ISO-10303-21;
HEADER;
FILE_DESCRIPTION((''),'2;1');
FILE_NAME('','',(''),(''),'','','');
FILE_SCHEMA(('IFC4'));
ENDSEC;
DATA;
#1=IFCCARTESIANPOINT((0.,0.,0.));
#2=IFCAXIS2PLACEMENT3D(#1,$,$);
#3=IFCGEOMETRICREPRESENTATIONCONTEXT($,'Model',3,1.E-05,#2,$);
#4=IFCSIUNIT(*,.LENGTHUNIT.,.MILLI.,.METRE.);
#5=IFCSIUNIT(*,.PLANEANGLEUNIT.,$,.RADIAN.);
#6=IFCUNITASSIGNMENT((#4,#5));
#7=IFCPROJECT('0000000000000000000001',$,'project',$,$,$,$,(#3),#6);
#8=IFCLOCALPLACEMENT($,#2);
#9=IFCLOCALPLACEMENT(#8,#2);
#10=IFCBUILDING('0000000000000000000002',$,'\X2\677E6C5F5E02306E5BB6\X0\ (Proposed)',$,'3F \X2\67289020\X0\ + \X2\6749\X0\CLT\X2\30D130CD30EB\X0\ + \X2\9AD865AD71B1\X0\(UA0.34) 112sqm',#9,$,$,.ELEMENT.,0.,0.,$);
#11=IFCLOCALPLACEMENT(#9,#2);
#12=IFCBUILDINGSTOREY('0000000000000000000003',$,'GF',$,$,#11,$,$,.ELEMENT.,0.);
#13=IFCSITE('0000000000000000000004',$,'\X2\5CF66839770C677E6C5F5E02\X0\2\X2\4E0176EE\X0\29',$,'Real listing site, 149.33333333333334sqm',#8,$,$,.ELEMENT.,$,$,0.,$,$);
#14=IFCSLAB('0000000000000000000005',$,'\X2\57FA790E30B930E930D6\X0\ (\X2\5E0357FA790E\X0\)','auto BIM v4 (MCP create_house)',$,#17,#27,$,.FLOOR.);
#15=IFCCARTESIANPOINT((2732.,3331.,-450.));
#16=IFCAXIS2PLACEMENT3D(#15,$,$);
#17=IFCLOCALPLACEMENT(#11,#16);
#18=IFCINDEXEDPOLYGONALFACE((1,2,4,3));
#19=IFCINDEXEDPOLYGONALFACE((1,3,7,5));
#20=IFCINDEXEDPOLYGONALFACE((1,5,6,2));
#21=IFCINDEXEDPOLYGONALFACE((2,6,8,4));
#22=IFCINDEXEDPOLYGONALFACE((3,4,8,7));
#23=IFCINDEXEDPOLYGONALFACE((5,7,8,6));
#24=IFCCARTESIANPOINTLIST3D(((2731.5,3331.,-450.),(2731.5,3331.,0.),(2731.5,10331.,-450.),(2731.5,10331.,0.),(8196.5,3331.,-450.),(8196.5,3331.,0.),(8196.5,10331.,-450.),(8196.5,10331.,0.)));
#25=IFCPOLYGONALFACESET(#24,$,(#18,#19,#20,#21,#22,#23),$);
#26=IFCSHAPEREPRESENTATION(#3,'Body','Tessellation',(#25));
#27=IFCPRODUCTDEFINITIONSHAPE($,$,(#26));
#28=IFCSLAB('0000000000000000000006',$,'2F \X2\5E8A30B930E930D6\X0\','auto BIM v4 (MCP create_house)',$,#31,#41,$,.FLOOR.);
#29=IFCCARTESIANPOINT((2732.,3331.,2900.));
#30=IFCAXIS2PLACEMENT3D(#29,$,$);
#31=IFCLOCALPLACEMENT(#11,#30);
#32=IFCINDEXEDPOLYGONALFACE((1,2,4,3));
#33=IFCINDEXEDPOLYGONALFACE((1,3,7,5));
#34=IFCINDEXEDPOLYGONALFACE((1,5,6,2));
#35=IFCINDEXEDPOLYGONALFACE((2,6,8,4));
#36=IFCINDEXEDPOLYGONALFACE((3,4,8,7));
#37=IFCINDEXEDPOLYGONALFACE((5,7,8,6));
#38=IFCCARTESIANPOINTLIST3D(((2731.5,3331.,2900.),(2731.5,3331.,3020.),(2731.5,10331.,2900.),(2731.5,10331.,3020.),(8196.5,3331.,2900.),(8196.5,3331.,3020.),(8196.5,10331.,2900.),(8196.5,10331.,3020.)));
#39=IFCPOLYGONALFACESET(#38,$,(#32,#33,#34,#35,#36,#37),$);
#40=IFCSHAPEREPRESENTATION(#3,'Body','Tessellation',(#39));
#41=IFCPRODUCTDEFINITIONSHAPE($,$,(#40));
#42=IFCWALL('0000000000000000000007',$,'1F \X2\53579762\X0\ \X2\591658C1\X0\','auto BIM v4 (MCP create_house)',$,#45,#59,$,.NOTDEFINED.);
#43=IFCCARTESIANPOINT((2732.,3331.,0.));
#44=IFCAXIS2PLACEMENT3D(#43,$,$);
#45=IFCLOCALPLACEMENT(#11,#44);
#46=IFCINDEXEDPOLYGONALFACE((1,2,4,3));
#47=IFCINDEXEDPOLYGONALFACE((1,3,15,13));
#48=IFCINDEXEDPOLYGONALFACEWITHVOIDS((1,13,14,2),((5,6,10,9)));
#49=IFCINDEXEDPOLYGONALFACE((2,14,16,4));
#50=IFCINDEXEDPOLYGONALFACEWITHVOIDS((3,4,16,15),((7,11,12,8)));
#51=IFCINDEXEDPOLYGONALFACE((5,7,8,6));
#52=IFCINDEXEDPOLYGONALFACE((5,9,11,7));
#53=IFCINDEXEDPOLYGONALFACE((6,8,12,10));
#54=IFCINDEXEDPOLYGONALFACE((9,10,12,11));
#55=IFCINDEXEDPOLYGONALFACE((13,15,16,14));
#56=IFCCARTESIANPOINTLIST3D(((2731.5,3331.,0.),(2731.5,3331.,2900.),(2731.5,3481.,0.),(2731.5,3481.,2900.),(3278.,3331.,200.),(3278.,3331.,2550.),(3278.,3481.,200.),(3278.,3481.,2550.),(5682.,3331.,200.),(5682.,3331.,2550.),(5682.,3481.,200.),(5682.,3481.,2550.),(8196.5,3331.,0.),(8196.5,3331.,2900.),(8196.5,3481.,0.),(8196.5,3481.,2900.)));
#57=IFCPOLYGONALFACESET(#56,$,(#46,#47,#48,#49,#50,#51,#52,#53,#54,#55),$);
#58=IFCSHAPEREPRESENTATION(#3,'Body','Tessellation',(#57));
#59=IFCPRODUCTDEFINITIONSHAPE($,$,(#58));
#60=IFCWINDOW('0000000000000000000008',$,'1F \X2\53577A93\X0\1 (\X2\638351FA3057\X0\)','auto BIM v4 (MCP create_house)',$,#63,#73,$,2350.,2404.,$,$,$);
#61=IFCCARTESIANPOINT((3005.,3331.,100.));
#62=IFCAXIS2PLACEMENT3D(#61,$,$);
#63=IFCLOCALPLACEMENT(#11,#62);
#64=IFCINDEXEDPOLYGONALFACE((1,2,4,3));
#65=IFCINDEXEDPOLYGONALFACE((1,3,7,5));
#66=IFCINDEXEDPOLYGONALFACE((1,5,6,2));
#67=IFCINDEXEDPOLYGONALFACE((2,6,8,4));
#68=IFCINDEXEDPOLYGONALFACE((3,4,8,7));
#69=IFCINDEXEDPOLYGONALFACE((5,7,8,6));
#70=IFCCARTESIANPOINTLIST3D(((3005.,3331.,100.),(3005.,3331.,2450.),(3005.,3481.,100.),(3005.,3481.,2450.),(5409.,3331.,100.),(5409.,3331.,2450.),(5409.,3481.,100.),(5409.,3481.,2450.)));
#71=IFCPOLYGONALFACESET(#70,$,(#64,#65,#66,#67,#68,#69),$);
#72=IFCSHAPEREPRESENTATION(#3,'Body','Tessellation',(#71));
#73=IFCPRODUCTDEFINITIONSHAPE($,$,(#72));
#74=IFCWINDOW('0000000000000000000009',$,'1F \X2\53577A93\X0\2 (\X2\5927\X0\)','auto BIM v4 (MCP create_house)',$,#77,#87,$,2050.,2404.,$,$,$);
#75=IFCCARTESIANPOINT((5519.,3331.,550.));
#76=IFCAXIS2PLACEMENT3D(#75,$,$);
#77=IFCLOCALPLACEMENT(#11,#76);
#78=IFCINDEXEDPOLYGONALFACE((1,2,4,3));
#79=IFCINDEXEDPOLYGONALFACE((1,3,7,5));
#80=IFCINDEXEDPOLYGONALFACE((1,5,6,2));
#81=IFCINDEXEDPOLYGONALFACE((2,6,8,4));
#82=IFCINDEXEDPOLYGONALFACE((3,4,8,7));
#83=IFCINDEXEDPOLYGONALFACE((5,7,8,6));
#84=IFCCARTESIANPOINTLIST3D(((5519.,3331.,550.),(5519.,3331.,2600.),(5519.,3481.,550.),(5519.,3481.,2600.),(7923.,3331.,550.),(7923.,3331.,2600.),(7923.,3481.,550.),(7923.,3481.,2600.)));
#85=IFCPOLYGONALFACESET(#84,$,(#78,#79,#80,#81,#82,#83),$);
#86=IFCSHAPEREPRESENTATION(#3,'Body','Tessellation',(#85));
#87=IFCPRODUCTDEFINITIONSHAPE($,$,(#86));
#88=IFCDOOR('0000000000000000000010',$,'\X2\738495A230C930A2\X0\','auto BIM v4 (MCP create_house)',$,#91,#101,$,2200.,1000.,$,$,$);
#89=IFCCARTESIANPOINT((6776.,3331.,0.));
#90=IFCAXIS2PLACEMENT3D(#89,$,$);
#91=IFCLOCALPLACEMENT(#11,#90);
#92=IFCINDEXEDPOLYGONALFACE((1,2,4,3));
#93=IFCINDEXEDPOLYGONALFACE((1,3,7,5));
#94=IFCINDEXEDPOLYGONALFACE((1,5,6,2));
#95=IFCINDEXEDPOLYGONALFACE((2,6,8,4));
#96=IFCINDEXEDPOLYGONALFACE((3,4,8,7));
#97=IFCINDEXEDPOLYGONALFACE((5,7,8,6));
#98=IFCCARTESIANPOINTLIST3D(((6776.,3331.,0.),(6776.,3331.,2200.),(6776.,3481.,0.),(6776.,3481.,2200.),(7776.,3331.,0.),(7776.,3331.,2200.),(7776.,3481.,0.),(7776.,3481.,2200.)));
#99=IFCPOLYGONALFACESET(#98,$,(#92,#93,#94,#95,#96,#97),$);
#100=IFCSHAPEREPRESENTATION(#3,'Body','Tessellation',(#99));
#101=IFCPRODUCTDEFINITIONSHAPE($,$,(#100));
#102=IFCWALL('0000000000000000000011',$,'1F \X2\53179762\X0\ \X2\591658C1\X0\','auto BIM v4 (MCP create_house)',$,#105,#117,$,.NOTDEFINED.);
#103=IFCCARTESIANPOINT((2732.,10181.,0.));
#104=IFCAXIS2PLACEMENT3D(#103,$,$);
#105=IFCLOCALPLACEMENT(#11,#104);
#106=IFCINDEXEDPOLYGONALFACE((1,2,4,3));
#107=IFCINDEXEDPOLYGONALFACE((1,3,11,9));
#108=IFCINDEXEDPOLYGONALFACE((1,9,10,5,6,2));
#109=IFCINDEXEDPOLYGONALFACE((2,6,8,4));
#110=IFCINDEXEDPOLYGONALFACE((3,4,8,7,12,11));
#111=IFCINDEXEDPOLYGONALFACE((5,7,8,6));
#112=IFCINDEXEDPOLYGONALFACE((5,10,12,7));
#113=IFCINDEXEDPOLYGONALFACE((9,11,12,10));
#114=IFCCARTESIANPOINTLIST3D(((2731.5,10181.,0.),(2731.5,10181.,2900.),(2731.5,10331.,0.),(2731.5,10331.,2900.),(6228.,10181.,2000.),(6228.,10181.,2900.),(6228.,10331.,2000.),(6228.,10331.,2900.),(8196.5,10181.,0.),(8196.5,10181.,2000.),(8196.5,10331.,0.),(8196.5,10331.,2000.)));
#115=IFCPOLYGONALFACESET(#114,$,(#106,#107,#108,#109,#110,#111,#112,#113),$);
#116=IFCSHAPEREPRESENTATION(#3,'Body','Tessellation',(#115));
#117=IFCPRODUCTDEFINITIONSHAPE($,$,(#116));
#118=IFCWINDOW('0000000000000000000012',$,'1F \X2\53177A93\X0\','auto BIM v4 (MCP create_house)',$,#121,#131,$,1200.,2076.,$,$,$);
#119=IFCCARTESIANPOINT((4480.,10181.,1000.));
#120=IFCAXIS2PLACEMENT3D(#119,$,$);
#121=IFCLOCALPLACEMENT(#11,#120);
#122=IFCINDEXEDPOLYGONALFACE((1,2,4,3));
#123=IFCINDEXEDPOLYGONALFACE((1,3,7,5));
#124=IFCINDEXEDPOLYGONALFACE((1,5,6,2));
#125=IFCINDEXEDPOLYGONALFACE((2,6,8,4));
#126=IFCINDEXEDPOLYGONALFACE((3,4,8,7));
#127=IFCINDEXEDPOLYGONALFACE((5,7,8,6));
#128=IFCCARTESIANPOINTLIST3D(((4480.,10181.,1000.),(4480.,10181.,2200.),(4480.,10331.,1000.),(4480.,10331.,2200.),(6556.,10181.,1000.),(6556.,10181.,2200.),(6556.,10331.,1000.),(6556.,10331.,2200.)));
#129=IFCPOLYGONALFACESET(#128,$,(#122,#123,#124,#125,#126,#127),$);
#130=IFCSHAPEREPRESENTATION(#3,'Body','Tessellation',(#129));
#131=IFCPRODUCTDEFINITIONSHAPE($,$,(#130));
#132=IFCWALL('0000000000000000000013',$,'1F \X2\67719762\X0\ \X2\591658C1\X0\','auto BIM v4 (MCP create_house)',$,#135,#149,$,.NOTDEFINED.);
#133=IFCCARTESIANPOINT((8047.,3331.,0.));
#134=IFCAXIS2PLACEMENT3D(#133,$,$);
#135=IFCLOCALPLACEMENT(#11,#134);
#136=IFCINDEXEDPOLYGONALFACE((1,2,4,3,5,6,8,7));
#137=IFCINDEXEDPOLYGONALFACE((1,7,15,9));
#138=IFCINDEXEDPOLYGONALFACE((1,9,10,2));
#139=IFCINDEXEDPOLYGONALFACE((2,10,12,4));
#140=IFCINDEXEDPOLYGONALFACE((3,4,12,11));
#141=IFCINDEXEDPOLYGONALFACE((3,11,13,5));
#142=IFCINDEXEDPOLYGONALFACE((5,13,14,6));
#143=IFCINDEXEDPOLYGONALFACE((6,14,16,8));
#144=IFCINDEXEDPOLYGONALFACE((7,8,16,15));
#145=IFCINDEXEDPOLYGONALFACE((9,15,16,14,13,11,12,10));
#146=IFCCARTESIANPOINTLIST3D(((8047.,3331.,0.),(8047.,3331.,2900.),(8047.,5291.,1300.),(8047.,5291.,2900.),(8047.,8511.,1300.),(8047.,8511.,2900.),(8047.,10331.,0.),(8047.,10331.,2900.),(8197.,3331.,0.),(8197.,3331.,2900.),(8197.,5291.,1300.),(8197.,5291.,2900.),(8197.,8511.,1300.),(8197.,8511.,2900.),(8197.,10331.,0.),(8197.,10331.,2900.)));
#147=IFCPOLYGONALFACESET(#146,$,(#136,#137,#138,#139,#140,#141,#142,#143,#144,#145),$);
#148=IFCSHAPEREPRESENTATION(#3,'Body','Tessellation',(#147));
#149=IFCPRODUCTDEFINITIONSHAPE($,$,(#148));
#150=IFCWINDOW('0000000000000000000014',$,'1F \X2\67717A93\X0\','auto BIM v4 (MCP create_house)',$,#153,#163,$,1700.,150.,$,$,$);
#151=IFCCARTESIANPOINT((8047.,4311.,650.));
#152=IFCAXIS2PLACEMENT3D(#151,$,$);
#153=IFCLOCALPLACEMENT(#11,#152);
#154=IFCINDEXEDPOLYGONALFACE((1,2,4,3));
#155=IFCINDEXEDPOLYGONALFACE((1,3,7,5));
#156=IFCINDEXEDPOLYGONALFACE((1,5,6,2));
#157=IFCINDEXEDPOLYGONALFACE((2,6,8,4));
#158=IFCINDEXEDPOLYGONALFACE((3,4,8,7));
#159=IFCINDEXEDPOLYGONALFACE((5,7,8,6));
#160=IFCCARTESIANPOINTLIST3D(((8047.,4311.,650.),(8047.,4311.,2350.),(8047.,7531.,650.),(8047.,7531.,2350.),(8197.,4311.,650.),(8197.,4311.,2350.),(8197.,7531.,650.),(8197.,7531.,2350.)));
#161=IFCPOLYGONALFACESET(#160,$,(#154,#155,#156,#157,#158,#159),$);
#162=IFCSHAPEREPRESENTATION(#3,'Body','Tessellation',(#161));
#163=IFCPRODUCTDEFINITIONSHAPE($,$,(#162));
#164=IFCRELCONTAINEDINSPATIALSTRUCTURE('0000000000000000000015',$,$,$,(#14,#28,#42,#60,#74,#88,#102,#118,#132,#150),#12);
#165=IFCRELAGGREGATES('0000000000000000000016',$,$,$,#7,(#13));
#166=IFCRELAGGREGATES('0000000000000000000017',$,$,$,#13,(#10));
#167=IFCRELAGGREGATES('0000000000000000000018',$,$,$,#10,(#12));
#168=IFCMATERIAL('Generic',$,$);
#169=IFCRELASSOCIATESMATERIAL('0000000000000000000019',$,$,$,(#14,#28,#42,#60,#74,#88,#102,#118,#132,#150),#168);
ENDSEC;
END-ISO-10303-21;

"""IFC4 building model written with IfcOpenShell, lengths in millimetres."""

from ifc_helpers import new_model, si_unit, frame, frame_2d, origin, place, context, project, spatial, rectangle, extrude, material, element, fill, save


model = new_model("IFC4")

# Units and contexts
model_context = context("Model", 3, precision=1e-05, world=origin())
ifc_project = project(units=[si_unit("LENGTHUNIT", "METRE", prefix="MILLI"), si_unit("PLANEANGLEUNIT", "RADIAN")], contexts=[model_context])

# Site, building, storey
site_placement = place(None, origin())
site = spatial("IfcSite", under=ifc_project, at=site_placement, Name="島根県松江市2丁目29", ObjectType="Real listing site, 149.33333333333334sqm", CompositionType="ELEMENT", RefElevation=0.0)
building_placement = place(site_placement, origin())
building = spatial("IfcBuilding", under=site, at=building_placement, Name="松江市の家 (Proposed)", ObjectType="3F 木造 + 杉CLTパネル + 高断熱(UA0.34) 112sqm", CompositionType="ELEMENT", ElevationOfRefHeight=0.0, ElevationOfTerrain=0.0)
storey_placement = place(building_placement, origin())
storey = spatial("IfcBuildingStorey", under=building, at=storey_placement, Name="GF", CompositionType="ELEMENT", Elevation=0.0)

# Slabs
ifc_material = material(Name="Generic")
slab_1_placement = place(storey_placement, frame((2732.0, 3331.0, -450.0)))
element("IfcSlab", 1, at=slab_1_placement, inside=storey, material=ifc_material, Name="基礎スラブ (布基礎)", Description="auto BIM v4 (MCP create_house)", PredefinedType="FLOOR", context=model_context, shape_type="SweptSolid", body=[
    extrude(rectangle(XDim=5465.0, YDim=7000.0, at=frame_2d((2732.0, 3500.0))), frame((2732.0, 3331.0, -450.0)), (0.0, 0.0, 1.0), 450.0),
])
slab_2_placement = place(storey_placement, frame((2732.0, 3331.0, 2900.0)))
element("IfcSlab", 2, at=slab_2_placement, inside=storey, material=ifc_material, Name="2F 床スラブ", Description="auto BIM v4 (MCP create_house)", PredefinedType="FLOOR", context=model_context, shape_type="SweptSolid", body=[
    extrude(rectangle(XDim=5465.0, YDim=7000.0, at=frame_2d((2732.0, 3500.0))), frame((2732.0, 3331.0, 2900.0)), (0.0, 0.0, 1.0), 120.0),
])

# Wall, openings, windows, door
wall_1_placement = place(storey_placement, frame((2732.0, 3331.0, 0.0)))
wall_1 = element("IfcWall", 3, at=wall_1_placement, inside=storey, material=ifc_material, Name="1F 南面 外壁", Description="auto BIM v4 (MCP create_house)", PredefinedType="NOTDEFINED", context=model_context, shape_type="SweptSolid", body=[
    extrude(rectangle(XDim=5465.0, YDim=150.0, at=frame_2d((2732.0, 75.0))), frame((2732.0, 3331.0, 0.0)), (0.0, 0.0, 1.0), 2900.0),
])
opening_1_placement = place(storey_placement, frame((3005.0, 3331.0, 100.0)))
opening_1 = element("IfcOpeningElement", 4, at=opening_1_placement, cuts=wall_1, PredefinedType="NOTDEFINED", context=model_context, shape_type="SweptSolid", body=[
    extrude(rectangle(XDim=2404.0, YDim=150.0, at=frame_2d((1202.0, 75.0))), frame((3005.0, 3331.0, 100.0)), (0.0, 0.0, 1.0), 2350.0),
])
opening_2_placement = place(storey_placement, frame((5519.0, 3331.0, 550.0)))
opening_2 = element("IfcOpeningElement", 5, at=opening_2_placement, cuts=wall_1, PredefinedType="NOTDEFINED", context=model_context, shape_type="SweptSolid", body=[
    extrude(rectangle(XDim=2404.0, YDim=150.0, at=frame_2d((1202.0, 75.0))), frame((5519.0, 3331.0, 550.0)), (0.0, 0.0, 1.0), 2050.0),
])
opening_3_placement = place(storey_placement, frame((6776.0, 3331.0, 0.0)))
opening_3 = element("IfcOpeningElement", 6, at=opening_3_placement, cuts=wall_1, PredefinedType="NOTDEFINED", context=model_context, shape_type="SweptSolid", body=[
    extrude(rectangle(XDim=1000.0, YDim=150.0, at=frame_2d((500.0, 75.0))), frame((6776.0, 3331.0, 0.0)), (0.0, 0.0, 1.0), 2200.0),
])
window_1_placement = place(storey_placement, frame((3005.0, 3331.0, 100.0)))
window_1 = element("IfcWindow", 7, at=window_1_placement, inside=storey, material=ifc_material, Name="1F 南窓1 (掃出し)", Description="auto BIM v4 (MCP create_house)", OverallHeight=2350.0, OverallWidth=2404.0, context=model_context, shape_type="SweptSolid", body=[
    extrude(rectangle(XDim=2404.0, YDim=150.0, at=frame_2d((1202.0, 75.0))), frame((3005.0, 3331.0, 100.0)), (0.0, 0.0, 1.0), 2350.0),
])
fill(opening_1, window_1)
window_2_placement = place(storey_placement, frame((5519.0, 3331.0, 550.0)))
window_2 = element("IfcWindow", 8, at=window_2_placement, inside=storey, material=ifc_material, Name="1F 南窓2 (大)", Description="auto BIM v4 (MCP create_house)", OverallHeight=2050.0, OverallWidth=2404.0, context=model_context, shape_type="SweptSolid", body=[
    extrude(rectangle(XDim=2404.0, YDim=150.0, at=frame_2d((1202.0, 75.0))), frame((5519.0, 3331.0, 550.0)), (0.0, 0.0, 1.0), 2050.0),
])
fill(opening_2, window_2)
door_placement = place(storey_placement, frame((6776.0, 3331.0, 0.0)))
door = element("IfcDoor", 9, at=door_placement, inside=storey, material=ifc_material, Name="玄関ドア", Description="auto BIM v4 (MCP create_house)", OverallHeight=2200.0, OverallWidth=1000.0, context=model_context, shape_type="SweptSolid", body=[
    extrude(rectangle(XDim=1000.0, YDim=150.0, at=frame_2d((500.0, 75.0))), frame((6776.0, 3331.0, 0.0)), (0.0, 0.0, 1.0), 2200.0),
])
fill(opening_3, door)

# Walls, openings, windows
wall_2_placement = place(storey_placement, frame((2732.0, 10181.0, 0.0)))
wall_2 = element("IfcWall", 10, at=wall_2_placement, inside=storey, material=ifc_material, Name="1F 北面 外壁", Description="auto BIM v4 (MCP create_house)", PredefinedType="NOTDEFINED", context=model_context, shape_type="SweptSolid", body=[
    extrude(rectangle(XDim=5465.0, YDim=150.0, at=frame_2d((2732.0, 75.0))), frame((2732.0, 10181.0, 0.0)), (0.0, 0.0, 1.0), 2900.0),
])
opening_4_placement = place(storey_placement, frame((4480.0, 10181.0, 1000.0)))
opening_4 = element("IfcOpeningElement", 11, at=opening_4_placement, cuts=wall_2, PredefinedType="NOTDEFINED", context=model_context, shape_type="SweptSolid", body=[
    extrude(rectangle(XDim=2076.0, YDim=150.0, at=frame_2d((1038.0, 75.0))), frame((4480.0, 10181.0, 1000.0)), (0.0, 0.0, 1.0), 1200.0),
])
window_3_placement = place(storey_placement, frame((4480.0, 10181.0, 1000.0)))
window_3 = element("IfcWindow", 12, at=window_3_placement, inside=storey, material=ifc_material, Name="1F 北窓", Description="auto BIM v4 (MCP create_house)", OverallHeight=1200.0, OverallWidth=2076.0, context=model_context, shape_type="SweptSolid", body=[
    extrude(rectangle(XDim=2076.0, YDim=150.0, at=frame_2d((1038.0, 75.0))), frame((4480.0, 10181.0, 1000.0)), (0.0, 0.0, 1.0), 1200.0),
])
fill(opening_4, window_3)
wall_3_placement = place(storey_placement, frame((8047.0, 3331.0, 0.0)))
wall_3 = element("IfcWall", 13, at=wall_3_placement, inside=storey, material=ifc_material, Name="1F 東面 外壁", Description="auto BIM v4 (MCP create_house)", PredefinedType="NOTDEFINED", context=model_context, shape_type="SweptSolid", body=[
    extrude(rectangle(XDim=150.0, YDim=7000.0, at=frame_2d((75.0, 3500.0))), frame((8047.0, 3331.0, 0.0)), (0.0, 0.0, 1.0), 2900.0),
])
opening_5_placement = place(storey_placement, frame((8047.0, 4311.0, 650.0)))
opening_5 = element("IfcOpeningElement", 14, at=opening_5_placement, cuts=wall_3, PredefinedType="NOTDEFINED", context=model_context, shape_type="SweptSolid", body=[
    extrude(rectangle(XDim=150.0, YDim=3220.0, at=frame_2d((75.0, 1610.0))), frame((8047.0, 4311.0, 650.0)), (0.0, 0.0, 1.0), 1700.0),
])
window_4_placement = place(storey_placement, frame((8047.0, 4311.0, 650.0)))
window_4 = element("IfcWindow", 15, at=window_4_placement, inside=storey, material=ifc_material, Name="1F 東窓", Description="auto BIM v4 (MCP create_house)", OverallHeight=1700.0, OverallWidth=150.0, context=model_context, shape_type="SweptSolid", body=[
    extrude(rectangle(XDim=150.0, YDim=3220.0, at=frame_2d((75.0, 1610.0))), frame((8047.0, 4311.0, 650.0)), (0.0, 0.0, 1.0), 1700.0),
])
fill(opening_5, window_4)

save(model, "model.ifc")
